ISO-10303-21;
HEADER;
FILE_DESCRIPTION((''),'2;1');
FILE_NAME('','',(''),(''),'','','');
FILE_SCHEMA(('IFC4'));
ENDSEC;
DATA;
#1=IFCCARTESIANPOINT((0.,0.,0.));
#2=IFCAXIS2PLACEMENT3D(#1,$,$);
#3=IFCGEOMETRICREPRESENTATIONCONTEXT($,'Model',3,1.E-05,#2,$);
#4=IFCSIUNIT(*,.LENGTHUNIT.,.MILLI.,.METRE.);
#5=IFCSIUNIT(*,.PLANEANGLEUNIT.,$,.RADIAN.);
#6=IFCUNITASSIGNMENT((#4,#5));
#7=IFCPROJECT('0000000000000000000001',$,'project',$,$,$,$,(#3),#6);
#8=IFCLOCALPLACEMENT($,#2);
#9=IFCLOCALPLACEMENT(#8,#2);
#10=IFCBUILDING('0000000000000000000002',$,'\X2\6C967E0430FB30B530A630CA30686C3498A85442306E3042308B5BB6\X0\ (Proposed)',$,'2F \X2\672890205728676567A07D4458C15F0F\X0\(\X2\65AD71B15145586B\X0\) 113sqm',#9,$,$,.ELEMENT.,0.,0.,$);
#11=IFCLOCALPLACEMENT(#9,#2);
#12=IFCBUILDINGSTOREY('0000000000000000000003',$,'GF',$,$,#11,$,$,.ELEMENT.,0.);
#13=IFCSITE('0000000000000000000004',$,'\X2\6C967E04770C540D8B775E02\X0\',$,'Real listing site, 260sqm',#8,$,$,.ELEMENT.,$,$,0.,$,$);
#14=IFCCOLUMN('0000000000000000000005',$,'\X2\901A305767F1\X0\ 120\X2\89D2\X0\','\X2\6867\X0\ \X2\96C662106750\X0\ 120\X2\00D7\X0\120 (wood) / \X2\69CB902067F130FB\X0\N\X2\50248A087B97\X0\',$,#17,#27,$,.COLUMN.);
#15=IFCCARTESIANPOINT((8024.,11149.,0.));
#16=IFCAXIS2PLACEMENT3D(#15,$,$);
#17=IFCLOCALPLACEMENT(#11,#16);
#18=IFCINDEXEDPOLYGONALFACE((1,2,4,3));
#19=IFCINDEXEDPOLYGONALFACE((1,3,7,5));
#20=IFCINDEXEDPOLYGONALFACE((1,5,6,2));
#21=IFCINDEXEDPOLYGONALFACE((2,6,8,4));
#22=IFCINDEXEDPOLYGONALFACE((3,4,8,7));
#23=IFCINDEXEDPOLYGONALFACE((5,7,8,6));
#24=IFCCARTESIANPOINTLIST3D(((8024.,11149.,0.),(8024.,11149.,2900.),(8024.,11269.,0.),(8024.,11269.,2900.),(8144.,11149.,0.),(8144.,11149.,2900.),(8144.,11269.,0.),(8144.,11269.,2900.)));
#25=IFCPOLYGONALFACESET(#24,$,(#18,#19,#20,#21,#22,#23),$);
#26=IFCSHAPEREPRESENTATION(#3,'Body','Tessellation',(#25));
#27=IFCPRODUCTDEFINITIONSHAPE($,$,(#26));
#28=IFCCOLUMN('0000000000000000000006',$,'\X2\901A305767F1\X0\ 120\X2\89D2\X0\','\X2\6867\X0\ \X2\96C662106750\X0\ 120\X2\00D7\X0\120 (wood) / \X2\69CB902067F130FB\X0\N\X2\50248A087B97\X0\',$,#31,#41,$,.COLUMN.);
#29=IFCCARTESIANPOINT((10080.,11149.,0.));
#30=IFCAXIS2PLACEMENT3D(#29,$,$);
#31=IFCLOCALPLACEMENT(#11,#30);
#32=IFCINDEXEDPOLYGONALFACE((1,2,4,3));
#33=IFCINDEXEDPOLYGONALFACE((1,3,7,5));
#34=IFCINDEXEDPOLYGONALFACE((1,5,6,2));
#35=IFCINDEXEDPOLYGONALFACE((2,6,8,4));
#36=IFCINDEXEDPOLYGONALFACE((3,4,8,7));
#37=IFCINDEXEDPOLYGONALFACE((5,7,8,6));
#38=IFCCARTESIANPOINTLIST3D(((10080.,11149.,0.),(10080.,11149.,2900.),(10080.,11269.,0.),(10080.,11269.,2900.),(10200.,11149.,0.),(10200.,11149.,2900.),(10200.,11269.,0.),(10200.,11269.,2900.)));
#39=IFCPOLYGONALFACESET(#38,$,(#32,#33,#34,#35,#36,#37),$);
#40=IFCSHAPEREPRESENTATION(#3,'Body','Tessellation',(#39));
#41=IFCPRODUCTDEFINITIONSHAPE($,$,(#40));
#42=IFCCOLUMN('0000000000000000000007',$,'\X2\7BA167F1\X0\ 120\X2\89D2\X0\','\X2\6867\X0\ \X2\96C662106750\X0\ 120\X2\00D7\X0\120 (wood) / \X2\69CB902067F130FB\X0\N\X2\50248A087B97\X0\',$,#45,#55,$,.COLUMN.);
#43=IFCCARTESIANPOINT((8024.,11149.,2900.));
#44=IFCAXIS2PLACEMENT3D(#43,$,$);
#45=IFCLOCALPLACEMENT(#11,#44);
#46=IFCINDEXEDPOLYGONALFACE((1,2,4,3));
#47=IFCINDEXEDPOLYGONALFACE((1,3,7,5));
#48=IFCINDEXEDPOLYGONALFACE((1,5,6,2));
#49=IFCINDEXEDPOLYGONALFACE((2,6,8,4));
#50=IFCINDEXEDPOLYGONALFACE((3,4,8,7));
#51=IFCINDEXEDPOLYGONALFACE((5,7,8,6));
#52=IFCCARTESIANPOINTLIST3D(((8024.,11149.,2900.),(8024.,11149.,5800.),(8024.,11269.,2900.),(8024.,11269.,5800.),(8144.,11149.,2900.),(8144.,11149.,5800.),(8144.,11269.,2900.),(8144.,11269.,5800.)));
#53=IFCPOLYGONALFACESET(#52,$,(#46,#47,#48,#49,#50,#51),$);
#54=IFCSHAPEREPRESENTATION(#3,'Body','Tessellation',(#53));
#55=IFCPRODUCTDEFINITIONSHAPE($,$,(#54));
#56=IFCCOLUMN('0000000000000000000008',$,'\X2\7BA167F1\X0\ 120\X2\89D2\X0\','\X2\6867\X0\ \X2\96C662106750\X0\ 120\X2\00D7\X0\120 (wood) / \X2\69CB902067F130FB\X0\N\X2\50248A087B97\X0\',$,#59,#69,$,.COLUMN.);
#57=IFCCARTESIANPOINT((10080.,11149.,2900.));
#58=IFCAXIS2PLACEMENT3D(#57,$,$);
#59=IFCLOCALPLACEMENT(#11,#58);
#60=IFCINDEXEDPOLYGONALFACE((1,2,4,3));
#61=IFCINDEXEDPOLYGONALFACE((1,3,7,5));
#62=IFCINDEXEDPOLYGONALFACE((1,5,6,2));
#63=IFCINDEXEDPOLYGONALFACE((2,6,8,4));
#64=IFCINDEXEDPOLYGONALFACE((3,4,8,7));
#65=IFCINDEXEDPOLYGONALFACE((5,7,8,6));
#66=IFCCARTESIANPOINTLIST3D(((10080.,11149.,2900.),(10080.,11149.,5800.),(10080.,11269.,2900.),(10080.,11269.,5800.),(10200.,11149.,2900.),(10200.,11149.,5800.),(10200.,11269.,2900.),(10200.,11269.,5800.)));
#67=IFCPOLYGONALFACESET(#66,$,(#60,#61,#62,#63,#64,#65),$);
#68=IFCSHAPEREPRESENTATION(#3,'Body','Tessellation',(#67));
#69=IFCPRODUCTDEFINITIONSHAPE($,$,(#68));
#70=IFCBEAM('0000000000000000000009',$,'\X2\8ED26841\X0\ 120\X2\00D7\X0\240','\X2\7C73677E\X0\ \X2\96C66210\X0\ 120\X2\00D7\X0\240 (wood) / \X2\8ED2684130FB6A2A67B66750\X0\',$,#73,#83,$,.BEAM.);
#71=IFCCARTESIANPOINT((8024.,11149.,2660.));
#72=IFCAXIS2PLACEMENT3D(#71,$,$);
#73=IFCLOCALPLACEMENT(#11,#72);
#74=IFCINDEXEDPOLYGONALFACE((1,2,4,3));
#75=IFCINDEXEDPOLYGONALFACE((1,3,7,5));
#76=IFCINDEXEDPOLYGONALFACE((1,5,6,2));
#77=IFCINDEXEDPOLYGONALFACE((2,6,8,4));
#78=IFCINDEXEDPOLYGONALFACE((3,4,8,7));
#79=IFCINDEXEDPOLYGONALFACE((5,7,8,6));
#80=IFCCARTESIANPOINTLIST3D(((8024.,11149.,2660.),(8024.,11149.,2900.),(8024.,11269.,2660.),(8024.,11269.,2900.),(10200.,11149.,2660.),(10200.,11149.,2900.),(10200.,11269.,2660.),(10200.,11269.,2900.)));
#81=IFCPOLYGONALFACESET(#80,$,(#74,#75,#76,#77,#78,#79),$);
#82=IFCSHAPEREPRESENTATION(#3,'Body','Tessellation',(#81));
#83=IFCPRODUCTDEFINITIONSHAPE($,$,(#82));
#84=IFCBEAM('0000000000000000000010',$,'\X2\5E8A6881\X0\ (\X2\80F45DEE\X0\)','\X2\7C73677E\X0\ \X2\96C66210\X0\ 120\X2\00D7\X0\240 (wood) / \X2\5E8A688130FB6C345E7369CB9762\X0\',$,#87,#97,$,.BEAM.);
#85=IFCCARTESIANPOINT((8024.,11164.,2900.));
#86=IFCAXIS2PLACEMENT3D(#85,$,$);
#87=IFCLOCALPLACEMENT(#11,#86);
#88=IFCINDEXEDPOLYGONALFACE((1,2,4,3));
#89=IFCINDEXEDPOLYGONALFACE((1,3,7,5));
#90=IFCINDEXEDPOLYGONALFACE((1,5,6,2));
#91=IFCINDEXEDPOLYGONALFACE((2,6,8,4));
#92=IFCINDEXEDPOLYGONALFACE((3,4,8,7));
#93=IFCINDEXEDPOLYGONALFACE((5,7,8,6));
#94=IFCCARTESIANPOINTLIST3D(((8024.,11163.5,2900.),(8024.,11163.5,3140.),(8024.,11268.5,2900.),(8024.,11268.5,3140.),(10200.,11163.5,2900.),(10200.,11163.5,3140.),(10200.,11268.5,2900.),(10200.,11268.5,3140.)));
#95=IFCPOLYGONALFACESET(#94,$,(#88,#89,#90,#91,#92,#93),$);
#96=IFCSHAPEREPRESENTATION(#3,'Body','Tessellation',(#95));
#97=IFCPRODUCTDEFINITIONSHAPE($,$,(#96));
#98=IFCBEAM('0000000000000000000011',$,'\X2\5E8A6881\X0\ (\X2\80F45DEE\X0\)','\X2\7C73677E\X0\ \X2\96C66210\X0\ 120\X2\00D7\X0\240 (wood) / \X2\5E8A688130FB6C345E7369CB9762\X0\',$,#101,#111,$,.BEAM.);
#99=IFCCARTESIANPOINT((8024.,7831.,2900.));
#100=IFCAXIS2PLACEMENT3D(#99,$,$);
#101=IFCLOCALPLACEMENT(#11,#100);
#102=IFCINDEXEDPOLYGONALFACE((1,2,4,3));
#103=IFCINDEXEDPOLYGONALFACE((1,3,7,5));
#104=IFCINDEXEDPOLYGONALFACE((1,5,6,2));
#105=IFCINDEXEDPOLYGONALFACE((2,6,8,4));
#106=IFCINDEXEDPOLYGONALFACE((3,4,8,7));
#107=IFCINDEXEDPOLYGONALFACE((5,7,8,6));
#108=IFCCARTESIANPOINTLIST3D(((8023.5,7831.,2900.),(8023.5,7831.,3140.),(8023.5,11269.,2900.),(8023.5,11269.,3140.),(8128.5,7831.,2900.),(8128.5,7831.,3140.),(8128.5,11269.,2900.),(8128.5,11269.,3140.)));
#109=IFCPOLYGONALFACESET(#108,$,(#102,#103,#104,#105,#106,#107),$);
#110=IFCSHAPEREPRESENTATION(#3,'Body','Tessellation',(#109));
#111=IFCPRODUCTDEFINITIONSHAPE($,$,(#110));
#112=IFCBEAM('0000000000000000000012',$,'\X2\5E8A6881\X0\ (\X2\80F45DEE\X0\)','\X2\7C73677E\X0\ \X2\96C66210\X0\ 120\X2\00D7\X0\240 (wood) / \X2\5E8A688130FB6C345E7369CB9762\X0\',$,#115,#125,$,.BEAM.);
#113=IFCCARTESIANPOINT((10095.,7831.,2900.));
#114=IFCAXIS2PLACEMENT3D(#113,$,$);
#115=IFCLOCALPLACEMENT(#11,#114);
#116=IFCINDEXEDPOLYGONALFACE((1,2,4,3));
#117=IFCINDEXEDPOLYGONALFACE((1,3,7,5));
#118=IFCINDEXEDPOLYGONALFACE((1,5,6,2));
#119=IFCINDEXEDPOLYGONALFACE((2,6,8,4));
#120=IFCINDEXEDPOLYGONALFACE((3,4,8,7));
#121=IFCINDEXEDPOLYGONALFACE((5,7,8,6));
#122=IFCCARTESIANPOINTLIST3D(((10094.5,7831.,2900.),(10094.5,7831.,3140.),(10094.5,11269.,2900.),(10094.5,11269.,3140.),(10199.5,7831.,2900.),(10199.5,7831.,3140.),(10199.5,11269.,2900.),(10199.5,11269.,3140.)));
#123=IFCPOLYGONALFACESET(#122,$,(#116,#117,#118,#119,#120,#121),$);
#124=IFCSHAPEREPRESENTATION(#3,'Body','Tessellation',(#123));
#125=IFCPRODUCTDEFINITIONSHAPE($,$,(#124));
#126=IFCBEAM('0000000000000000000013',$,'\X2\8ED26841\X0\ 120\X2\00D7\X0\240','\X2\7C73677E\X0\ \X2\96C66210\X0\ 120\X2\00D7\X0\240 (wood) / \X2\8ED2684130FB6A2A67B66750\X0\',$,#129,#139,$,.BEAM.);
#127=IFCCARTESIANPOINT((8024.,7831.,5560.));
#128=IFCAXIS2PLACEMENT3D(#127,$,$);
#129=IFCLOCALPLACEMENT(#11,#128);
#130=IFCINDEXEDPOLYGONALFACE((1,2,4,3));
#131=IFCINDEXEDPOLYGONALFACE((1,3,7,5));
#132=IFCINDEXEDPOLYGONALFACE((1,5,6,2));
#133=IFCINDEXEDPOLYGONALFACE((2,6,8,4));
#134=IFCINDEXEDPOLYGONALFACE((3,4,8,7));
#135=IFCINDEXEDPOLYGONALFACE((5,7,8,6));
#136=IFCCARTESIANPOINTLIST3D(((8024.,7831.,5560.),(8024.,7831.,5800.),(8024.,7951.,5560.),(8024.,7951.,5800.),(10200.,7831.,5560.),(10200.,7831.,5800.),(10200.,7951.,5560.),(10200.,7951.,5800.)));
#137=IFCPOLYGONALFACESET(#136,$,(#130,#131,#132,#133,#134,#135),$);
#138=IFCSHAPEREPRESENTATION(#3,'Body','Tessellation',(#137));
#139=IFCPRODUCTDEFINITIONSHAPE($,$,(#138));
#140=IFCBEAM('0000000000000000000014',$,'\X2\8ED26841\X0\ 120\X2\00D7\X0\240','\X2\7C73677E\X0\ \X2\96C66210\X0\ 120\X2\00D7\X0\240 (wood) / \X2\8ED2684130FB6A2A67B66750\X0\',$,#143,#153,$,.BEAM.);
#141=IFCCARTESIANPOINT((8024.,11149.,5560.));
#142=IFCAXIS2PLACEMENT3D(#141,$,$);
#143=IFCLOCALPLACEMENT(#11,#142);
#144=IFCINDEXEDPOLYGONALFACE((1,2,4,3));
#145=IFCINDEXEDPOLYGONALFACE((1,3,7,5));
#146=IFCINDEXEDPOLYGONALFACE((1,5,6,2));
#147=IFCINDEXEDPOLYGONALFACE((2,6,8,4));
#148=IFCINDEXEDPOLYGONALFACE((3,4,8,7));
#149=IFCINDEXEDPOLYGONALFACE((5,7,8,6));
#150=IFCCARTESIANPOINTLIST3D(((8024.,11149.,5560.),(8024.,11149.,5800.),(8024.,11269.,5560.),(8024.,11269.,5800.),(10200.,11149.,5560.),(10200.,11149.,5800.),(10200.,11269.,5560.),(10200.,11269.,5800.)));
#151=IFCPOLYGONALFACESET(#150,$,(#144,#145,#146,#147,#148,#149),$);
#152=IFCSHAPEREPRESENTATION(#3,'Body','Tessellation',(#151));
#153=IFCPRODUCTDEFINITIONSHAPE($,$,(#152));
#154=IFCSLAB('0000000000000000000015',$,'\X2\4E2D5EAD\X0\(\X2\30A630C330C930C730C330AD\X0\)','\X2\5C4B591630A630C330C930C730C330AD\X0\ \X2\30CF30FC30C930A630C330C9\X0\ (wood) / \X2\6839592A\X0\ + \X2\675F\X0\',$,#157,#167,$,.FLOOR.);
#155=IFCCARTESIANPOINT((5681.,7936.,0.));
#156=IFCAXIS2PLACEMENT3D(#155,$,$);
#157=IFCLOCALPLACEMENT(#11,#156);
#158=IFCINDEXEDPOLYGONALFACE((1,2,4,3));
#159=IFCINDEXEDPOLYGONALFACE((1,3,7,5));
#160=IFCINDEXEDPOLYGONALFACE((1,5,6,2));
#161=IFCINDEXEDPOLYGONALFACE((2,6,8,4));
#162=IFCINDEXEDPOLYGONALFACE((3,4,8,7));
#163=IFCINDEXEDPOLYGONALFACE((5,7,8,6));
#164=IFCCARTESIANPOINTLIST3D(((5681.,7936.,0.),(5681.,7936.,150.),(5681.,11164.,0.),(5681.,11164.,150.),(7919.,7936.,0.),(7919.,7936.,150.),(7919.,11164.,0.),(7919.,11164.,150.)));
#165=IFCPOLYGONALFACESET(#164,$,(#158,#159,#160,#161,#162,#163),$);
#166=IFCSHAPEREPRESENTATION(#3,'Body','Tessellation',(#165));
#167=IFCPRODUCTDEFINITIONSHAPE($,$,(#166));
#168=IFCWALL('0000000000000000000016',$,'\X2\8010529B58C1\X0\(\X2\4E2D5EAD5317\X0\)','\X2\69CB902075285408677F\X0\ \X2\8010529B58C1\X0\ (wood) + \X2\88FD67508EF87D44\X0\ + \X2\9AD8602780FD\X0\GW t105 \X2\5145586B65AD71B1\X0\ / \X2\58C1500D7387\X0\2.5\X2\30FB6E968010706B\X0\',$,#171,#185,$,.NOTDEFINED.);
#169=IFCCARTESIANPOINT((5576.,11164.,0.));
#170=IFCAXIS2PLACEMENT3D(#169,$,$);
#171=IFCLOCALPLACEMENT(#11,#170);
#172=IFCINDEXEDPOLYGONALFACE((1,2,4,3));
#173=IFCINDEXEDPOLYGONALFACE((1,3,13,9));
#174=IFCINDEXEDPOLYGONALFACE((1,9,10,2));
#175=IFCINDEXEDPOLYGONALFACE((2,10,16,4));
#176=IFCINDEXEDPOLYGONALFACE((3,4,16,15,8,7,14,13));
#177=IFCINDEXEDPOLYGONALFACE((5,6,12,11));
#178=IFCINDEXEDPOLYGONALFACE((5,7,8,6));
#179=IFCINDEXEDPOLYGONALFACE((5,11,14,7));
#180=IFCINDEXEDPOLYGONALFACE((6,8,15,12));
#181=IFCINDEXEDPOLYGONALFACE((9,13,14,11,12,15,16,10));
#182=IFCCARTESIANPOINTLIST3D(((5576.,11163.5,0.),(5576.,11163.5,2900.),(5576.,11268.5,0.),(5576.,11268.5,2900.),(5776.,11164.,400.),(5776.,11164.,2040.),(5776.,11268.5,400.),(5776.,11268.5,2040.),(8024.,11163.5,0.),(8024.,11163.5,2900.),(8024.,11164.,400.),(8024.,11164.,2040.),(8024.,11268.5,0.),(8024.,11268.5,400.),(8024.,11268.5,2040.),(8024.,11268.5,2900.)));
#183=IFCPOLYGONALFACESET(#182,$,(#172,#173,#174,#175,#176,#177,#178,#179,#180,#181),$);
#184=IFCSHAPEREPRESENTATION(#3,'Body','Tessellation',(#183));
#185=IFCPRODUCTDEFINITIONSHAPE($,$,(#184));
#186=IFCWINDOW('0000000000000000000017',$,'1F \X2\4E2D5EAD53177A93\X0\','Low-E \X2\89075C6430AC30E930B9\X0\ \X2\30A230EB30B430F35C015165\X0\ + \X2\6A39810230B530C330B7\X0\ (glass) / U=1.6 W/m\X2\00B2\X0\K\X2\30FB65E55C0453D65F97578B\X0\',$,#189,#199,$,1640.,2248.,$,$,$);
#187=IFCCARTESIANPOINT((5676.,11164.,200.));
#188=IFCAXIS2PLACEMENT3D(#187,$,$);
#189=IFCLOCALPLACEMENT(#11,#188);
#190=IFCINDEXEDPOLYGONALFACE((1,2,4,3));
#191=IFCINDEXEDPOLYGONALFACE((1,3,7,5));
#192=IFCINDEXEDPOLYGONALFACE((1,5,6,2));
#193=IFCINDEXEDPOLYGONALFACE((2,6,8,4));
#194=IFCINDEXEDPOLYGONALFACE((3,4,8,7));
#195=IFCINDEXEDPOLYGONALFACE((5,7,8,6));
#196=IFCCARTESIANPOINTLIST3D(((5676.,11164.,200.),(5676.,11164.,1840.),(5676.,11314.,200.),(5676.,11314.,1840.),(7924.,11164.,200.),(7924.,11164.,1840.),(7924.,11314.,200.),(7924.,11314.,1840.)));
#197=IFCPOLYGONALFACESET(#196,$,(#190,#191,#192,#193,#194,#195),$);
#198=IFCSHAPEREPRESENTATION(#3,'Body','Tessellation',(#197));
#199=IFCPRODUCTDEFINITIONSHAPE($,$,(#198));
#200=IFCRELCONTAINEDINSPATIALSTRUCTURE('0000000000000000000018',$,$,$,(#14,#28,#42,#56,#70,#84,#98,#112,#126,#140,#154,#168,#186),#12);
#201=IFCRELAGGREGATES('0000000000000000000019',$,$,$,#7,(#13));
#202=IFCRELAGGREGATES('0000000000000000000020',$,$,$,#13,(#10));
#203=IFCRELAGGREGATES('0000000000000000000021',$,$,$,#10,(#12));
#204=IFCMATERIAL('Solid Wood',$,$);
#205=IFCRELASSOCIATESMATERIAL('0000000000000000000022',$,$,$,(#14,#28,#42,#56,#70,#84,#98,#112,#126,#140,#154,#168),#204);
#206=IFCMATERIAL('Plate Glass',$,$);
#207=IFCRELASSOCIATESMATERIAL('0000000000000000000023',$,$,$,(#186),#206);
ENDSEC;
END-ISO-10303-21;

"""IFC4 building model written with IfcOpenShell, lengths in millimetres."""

from ifc_helpers import new_model, si_unit, frame, frame_2d, origin, place, context, project, spatial, rectangle, extrude, material, element, fill, save


model = new_model("IFC4")

# Units and contexts
model_context = context("Model", 3, precision=1e-05, world=origin())
ifc_project = project(units=[si_unit("LENGTHUNIT", "METRE", prefix="MILLI"), si_unit("PLANEANGLEUNIT", "RADIAN")], contexts=[model_context])

# Site, building, storey
site_placement = place(None, origin())
site = spatial("IfcSite", under=ifc_project, at=site_placement, Name="沖縄県名護市", ObjectType="Real listing site, 260sqm", CompositionType="ELEMENT", RefElevation=0.0)
building_placement = place(site_placement, origin())
building = spatial("IfcBuilding", under=site, at=building_placement, Name="沖縄・サウナと水風呂のある家 (Proposed)", ObjectType="2F 木造在来枠組壁式(断熱充填) 113sqm", CompositionType="ELEMENT", ElevationOfRefHeight=0.0, ElevationOfTerrain=0.0)
storey_placement = place(building_placement, origin())
storey = spatial("IfcBuildingStorey", under=building, at=storey_placement, Name="GF", CompositionType="ELEMENT", Elevation=0.0)

# Columns
ifc_material_1 = material(Name="Solid Wood")
column_1_placement = place(storey_placement, frame((8024.0, 11149.0, 0.0)))
element("IfcColumn", 1, at=column_1_placement, inside=storey, material=ifc_material_1, Name="通し柱 120角", Description="桧 集成材 120×120 (wood) / 構造柱・N値計算", PredefinedType="COLUMN", context=model_context, shape_type="SweptSolid", body=[
    extrude(rectangle(XDim=120.0, YDim=120.0, at=frame_2d((60.0, 60.0))), frame((8024.0, 11149.0, 0.0)), (0.0, 0.0, 1.0), 2900.0),
])
column_2_placement = place(storey_placement, frame((10080.0, 11149.0, 0.0)))
element("IfcColumn", 2, at=column_2_placement, inside=storey, material=ifc_material_1, Name="通し柱 120角", Description="桧 集成材 120×120 (wood) / 構造柱・N値計算", PredefinedType="COLUMN", context=model_context, shape_type="SweptSolid", body=[
    extrude(rectangle(XDim=120.0, YDim=120.0, at=frame_2d((60.0, 60.0))), frame((10080.0, 11149.0, 0.0)), (0.0, 0.0, 1.0), 2900.0),
])
column_3_placement = place(storey_placement, frame((8024.0, 11149.0, 2900.0)))
element("IfcColumn", 3, at=column_3_placement, inside=storey, material=ifc_material_1, Name="管柱 120角", Description="桧 集成材 120×120 (wood) / 構造柱・N値計算", PredefinedType="COLUMN", context=model_context, shape_type="SweptSolid", body=[
    extrude(rectangle(XDim=120.0, YDim=120.0, at=frame_2d((60.0, 60.0))), frame((8024.0, 11149.0, 2900.0)), (0.0, 0.0, 1.0), 2900.0),
])
column_4_placement = place(storey_placement, frame((10080.0, 11149.0, 2900.0)))
element("IfcColumn", 4, at=column_4_placement, inside=storey, material=ifc_material_1, Name="管柱 120角", Description="桧 集成材 120×120 (wood) / 構造柱・N値計算", PredefinedType="COLUMN", context=model_context, shape_type="SweptSolid", body=[
    extrude(rectangle(XDim=120.0, YDim=120.0, at=frame_2d((60.0, 60.0))), frame((10080.0, 11149.0, 2900.0)), (0.0, 0.0, 1.0), 2900.0),
])

# Beams
beam_1_placement = place(storey_placement, frame((8024.0, 11149.0, 2660.0)))
element("IfcBeam", 5, at=beam_1_placement, inside=storey, material=ifc_material_1, Name="軒桁 120×240", Description="米松 集成 120×240 (wood) / 軒桁・横架材", PredefinedType="BEAM", context=model_context, shape_type="SweptSolid", body=[
    extrude(rectangle(XDim=2176.0, YDim=120.0, at=frame_2d((1088.0, 60.0))), frame((8024.0, 11149.0, 2660.0)), (0.0, 0.0, 1.0), 240.0),
])
beam_2_placement = place(storey_placement, frame((8024.0, 11164.0, 2900.0)))
element("IfcBeam", 6, at=beam_2_placement, inside=storey, material=ifc_material_1, Name="床梁 (胴差)", Description="米松 集成 120×240 (wood) / 床梁・水平構面", PredefinedType="BEAM", context=model_context, shape_type="SweptSolid", body=[
    extrude(rectangle(XDim=2176.0, YDim=105.0, at=frame_2d((1088.0, 52.0))), frame((8024.0, 11164.0, 2900.0)), (0.0, 0.0, 1.0), 240.0),
])
beam_3_placement = place(storey_placement, frame((8024.0, 7831.0, 2900.0)))
element("IfcBeam", 7, at=beam_3_placement, inside=storey, material=ifc_material_1, Name="床梁 (胴差)", Description="米松 集成 120×240 (wood) / 床梁・水平構面", PredefinedType="BEAM", context=model_context, shape_type="SweptSolid", body=[
    extrude(rectangle(XDim=105.0, YDim=3438.0, at=frame_2d((52.0, 1719.0))), frame((8024.0, 7831.0, 2900.0)), (0.0, 0.0, 1.0), 240.0),
])
beam_4_placement = place(storey_placement, frame((10095.0, 7831.0, 2900.0)))
element("IfcBeam", 8, at=beam_4_placement, inside=storey, material=ifc_material_1, Name="床梁 (胴差)", Description="米松 集成 120×240 (wood) / 床梁・水平構面", PredefinedType="BEAM", context=model_context, shape_type="SweptSolid", body=[
    extrude(rectangle(XDim=105.0, YDim=3438.0, at=frame_2d((52.0, 1719.0))), frame((10095.0, 7831.0, 2900.0)), (0.0, 0.0, 1.0), 240.0),
])
beam_5_placement = place(storey_placement, frame((8024.0, 7831.0, 5560.0)))
element("IfcBeam", 9, at=beam_5_placement, inside=storey, material=ifc_material_1, Name="軒桁 120×240", Description="米松 集成 120×240 (wood) / 軒桁・横架材", PredefinedType="BEAM", context=model_context, shape_type="SweptSolid", body=[
    extrude(rectangle(XDim=2176.0, YDim=120.0, at=frame_2d((1088.0, 60.0))), frame((8024.0, 7831.0, 5560.0)), (0.0, 0.0, 1.0), 240.0),
])
beam_6_placement = place(storey_placement, frame((8024.0, 11149.0, 5560.0)))
element("IfcBeam", 10, at=beam_6_placement, inside=storey, material=ifc_material_1, Name="軒桁 120×240", Description="米松 集成 120×240 (wood) / 軒桁・横架材", PredefinedType="BEAM", context=model_context, shape_type="SweptSolid", body=[
    extrude(rectangle(XDim=2176.0, YDim=120.0, at=frame_2d((1088.0, 60.0))), frame((8024.0, 11149.0, 5560.0)), (0.0, 0.0, 1.0), 240.0),
])

# Slab
slab_placement = place(storey_placement, frame((5681.0, 7936.0, 0.0)))
element("IfcSlab", 11, at=slab_placement, inside=storey, material=ifc_material_1, Name="中庭(ウッドデッキ)", Description="屋外ウッドデッキ ハードウッド (wood) / 根太 + 束", PredefinedType="FLOOR", context=model_context, shape_type="SweptSolid", body=[
    extrude(rectangle(XDim=2238.0, YDim=3228.0, at=frame_2d((1119.0, 1614.0))), frame((5681.0, 7936.0, 0.0)), (0.0, 0.0, 1.0), 150.0),
])

# Wall, opening, window
wall_1_placement = place(storey_placement, frame((5576.0, 11164.0, 0.0)))
wall_1 = element("IfcWall", 12, at=wall_1_placement, inside=storey, material=ifc_material_1, Name="耐力壁(中庭北)", Description="構造用合板 耐力壁 (wood) + 製材軸組 + 高性能GW t105 充填断熱 / 壁倍率2.5・準耐火", PredefinedType="NOTDEFINED", context=model_context, shape_type="SweptSolid", body=[
    extrude(rectangle(XDim=2448.0, YDim=105.0, at=frame_2d((1224.0, 52.0))), frame((5576.0, 11164.0, 0.0)), (0.0, 0.0, 1.0), 2900.0),
])
opening_1_placement = place(storey_placement, frame((5676.0, 11164.0, 200.0)))
opening_1 = element("IfcOpeningElement", 13, at=opening_1_placement, cuts=wall_1, PredefinedType="NOTDEFINED", context=model_context, shape_type="SweptSolid", body=[
    extrude(rectangle(XDim=2248.0, YDim=150.0, at=frame_2d((1124.0, 75.0))), frame((5676.0, 11164.0, 200.0)), (0.0, 0.0, 1.0), 1640.0),
])
ifc_material_2 = material(Name="Plate Glass")
window_1_placement = place(storey_placement, frame((5676.0, 11164.0, 200.0)))
window_1 = element("IfcWindow", 14, at=window_1_placement, inside=storey, material=ifc_material_2, Name="1F 中庭北窓", Description="Low-E 複層ガラス アルゴン封入 + 樹脂サッシ (glass) / U=1.6 W/m²K・日射取得型", OverallHeight=1640.0, OverallWidth=2248.0, context=model_context, shape_type="SweptSolid", body=[
    extrude(rectangle(XDim=2248.0, YDim=150.0, at=frame_2d((1124.0, 75.0))), frame((5676.0, 11164.0, 200.0)), (0.0, 0.0, 1.0), 1640.0),
])
fill(opening_1, window_1)

save(model, "model.ifc")
